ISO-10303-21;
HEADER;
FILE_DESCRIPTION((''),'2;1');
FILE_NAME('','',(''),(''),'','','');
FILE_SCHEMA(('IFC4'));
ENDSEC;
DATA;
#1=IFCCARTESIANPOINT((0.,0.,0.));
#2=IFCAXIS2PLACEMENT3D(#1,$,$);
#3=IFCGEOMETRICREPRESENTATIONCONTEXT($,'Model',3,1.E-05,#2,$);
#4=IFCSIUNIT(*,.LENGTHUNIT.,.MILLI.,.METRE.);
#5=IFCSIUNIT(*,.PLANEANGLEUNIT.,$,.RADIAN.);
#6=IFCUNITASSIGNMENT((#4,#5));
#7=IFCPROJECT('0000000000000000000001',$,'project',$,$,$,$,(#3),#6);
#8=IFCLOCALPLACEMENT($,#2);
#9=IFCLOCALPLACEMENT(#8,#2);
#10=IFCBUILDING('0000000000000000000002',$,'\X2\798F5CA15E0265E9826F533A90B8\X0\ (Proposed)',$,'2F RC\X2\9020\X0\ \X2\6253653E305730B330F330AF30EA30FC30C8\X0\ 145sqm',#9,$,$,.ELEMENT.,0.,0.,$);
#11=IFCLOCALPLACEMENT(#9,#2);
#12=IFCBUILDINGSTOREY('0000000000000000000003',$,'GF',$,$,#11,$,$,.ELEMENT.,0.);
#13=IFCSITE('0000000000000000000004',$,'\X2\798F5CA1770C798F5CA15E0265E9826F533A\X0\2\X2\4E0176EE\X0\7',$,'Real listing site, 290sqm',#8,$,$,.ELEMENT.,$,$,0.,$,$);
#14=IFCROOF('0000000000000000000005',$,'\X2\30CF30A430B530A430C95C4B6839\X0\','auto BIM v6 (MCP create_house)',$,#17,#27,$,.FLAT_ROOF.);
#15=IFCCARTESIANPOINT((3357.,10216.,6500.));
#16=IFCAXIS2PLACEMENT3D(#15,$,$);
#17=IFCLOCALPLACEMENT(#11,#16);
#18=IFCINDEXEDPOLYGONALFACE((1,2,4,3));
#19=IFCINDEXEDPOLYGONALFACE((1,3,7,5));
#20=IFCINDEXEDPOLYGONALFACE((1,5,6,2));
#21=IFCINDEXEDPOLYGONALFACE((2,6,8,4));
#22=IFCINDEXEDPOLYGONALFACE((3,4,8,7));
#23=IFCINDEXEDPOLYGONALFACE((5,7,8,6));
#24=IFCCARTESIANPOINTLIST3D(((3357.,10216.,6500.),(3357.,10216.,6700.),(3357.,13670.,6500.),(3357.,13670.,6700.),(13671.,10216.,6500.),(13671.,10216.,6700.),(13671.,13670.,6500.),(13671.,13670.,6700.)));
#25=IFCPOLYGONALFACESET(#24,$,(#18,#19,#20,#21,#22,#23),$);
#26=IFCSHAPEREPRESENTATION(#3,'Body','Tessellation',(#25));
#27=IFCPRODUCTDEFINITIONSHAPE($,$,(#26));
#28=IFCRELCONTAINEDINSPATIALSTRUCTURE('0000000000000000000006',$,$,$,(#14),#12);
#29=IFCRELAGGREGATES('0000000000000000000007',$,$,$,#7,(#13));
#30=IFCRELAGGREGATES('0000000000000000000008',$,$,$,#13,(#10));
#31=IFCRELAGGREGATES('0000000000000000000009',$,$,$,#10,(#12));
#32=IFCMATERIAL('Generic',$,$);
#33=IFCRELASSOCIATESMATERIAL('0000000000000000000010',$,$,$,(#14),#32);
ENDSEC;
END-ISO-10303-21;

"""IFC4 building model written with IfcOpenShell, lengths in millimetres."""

from ifc_helpers import new_model, si_unit, frame, frame_2d, origin, place, context, project, spatial, rectangle, extrude, material, element, save


model = new_model("IFC4")

# Units and contexts
model_context = context("Model", 3, precision=1e-05, world=origin())
ifc_project = project(units=[si_unit("LENGTHUNIT", "METRE", prefix="MILLI"), si_unit("PLANEANGLEUNIT", "RADIAN")], contexts=[model_context])

# Site, building, storey
site_placement = place(None, origin())
site = spatial("IfcSite", under=ifc_project, at=site_placement, Name="福岡県福岡市早良区2丁目7", ObjectType="Real listing site, 290sqm", CompositionType="ELEMENT", RefElevation=0.0)
building_placement = place(site_placement, origin())
building = spatial("IfcBuilding", under=site, at=building_placement, Name="福岡市早良区邸 (Proposed)", ObjectType="2F RC造 打放しコンクリート 145sqm", CompositionType="ELEMENT", ElevationOfRefHeight=0.0, ElevationOfTerrain=0.0)
storey_placement = place(building_placement, origin())
storey = spatial("IfcBuildingStorey", under=building, at=storey_placement, Name="GF", CompositionType="ELEMENT", Elevation=0.0)

# Shared definitions
ifc_material = material(Name="Generic")

# Roof
roof_placement = place(storey_placement, frame((3357.0, 10216.0, 6500.0)))
element("IfcRoof", 1, at=roof_placement, inside=storey, material=ifc_material, Name="ハイサイド屋根", Description="auto BIM v6 (MCP create_house)", PredefinedType="FLAT_ROOF", context=model_context, shape_type="SweptSolid", body=[
    extrude(rectangle(XDim=10314.0, YDim=3454.0, at=frame_2d((5157.0, 1727.0))), frame((3357.0, 10216.0, 6500.0)), (0.0, 0.0, 1.0), 200.0),
])

save(model, "model.ifc")
